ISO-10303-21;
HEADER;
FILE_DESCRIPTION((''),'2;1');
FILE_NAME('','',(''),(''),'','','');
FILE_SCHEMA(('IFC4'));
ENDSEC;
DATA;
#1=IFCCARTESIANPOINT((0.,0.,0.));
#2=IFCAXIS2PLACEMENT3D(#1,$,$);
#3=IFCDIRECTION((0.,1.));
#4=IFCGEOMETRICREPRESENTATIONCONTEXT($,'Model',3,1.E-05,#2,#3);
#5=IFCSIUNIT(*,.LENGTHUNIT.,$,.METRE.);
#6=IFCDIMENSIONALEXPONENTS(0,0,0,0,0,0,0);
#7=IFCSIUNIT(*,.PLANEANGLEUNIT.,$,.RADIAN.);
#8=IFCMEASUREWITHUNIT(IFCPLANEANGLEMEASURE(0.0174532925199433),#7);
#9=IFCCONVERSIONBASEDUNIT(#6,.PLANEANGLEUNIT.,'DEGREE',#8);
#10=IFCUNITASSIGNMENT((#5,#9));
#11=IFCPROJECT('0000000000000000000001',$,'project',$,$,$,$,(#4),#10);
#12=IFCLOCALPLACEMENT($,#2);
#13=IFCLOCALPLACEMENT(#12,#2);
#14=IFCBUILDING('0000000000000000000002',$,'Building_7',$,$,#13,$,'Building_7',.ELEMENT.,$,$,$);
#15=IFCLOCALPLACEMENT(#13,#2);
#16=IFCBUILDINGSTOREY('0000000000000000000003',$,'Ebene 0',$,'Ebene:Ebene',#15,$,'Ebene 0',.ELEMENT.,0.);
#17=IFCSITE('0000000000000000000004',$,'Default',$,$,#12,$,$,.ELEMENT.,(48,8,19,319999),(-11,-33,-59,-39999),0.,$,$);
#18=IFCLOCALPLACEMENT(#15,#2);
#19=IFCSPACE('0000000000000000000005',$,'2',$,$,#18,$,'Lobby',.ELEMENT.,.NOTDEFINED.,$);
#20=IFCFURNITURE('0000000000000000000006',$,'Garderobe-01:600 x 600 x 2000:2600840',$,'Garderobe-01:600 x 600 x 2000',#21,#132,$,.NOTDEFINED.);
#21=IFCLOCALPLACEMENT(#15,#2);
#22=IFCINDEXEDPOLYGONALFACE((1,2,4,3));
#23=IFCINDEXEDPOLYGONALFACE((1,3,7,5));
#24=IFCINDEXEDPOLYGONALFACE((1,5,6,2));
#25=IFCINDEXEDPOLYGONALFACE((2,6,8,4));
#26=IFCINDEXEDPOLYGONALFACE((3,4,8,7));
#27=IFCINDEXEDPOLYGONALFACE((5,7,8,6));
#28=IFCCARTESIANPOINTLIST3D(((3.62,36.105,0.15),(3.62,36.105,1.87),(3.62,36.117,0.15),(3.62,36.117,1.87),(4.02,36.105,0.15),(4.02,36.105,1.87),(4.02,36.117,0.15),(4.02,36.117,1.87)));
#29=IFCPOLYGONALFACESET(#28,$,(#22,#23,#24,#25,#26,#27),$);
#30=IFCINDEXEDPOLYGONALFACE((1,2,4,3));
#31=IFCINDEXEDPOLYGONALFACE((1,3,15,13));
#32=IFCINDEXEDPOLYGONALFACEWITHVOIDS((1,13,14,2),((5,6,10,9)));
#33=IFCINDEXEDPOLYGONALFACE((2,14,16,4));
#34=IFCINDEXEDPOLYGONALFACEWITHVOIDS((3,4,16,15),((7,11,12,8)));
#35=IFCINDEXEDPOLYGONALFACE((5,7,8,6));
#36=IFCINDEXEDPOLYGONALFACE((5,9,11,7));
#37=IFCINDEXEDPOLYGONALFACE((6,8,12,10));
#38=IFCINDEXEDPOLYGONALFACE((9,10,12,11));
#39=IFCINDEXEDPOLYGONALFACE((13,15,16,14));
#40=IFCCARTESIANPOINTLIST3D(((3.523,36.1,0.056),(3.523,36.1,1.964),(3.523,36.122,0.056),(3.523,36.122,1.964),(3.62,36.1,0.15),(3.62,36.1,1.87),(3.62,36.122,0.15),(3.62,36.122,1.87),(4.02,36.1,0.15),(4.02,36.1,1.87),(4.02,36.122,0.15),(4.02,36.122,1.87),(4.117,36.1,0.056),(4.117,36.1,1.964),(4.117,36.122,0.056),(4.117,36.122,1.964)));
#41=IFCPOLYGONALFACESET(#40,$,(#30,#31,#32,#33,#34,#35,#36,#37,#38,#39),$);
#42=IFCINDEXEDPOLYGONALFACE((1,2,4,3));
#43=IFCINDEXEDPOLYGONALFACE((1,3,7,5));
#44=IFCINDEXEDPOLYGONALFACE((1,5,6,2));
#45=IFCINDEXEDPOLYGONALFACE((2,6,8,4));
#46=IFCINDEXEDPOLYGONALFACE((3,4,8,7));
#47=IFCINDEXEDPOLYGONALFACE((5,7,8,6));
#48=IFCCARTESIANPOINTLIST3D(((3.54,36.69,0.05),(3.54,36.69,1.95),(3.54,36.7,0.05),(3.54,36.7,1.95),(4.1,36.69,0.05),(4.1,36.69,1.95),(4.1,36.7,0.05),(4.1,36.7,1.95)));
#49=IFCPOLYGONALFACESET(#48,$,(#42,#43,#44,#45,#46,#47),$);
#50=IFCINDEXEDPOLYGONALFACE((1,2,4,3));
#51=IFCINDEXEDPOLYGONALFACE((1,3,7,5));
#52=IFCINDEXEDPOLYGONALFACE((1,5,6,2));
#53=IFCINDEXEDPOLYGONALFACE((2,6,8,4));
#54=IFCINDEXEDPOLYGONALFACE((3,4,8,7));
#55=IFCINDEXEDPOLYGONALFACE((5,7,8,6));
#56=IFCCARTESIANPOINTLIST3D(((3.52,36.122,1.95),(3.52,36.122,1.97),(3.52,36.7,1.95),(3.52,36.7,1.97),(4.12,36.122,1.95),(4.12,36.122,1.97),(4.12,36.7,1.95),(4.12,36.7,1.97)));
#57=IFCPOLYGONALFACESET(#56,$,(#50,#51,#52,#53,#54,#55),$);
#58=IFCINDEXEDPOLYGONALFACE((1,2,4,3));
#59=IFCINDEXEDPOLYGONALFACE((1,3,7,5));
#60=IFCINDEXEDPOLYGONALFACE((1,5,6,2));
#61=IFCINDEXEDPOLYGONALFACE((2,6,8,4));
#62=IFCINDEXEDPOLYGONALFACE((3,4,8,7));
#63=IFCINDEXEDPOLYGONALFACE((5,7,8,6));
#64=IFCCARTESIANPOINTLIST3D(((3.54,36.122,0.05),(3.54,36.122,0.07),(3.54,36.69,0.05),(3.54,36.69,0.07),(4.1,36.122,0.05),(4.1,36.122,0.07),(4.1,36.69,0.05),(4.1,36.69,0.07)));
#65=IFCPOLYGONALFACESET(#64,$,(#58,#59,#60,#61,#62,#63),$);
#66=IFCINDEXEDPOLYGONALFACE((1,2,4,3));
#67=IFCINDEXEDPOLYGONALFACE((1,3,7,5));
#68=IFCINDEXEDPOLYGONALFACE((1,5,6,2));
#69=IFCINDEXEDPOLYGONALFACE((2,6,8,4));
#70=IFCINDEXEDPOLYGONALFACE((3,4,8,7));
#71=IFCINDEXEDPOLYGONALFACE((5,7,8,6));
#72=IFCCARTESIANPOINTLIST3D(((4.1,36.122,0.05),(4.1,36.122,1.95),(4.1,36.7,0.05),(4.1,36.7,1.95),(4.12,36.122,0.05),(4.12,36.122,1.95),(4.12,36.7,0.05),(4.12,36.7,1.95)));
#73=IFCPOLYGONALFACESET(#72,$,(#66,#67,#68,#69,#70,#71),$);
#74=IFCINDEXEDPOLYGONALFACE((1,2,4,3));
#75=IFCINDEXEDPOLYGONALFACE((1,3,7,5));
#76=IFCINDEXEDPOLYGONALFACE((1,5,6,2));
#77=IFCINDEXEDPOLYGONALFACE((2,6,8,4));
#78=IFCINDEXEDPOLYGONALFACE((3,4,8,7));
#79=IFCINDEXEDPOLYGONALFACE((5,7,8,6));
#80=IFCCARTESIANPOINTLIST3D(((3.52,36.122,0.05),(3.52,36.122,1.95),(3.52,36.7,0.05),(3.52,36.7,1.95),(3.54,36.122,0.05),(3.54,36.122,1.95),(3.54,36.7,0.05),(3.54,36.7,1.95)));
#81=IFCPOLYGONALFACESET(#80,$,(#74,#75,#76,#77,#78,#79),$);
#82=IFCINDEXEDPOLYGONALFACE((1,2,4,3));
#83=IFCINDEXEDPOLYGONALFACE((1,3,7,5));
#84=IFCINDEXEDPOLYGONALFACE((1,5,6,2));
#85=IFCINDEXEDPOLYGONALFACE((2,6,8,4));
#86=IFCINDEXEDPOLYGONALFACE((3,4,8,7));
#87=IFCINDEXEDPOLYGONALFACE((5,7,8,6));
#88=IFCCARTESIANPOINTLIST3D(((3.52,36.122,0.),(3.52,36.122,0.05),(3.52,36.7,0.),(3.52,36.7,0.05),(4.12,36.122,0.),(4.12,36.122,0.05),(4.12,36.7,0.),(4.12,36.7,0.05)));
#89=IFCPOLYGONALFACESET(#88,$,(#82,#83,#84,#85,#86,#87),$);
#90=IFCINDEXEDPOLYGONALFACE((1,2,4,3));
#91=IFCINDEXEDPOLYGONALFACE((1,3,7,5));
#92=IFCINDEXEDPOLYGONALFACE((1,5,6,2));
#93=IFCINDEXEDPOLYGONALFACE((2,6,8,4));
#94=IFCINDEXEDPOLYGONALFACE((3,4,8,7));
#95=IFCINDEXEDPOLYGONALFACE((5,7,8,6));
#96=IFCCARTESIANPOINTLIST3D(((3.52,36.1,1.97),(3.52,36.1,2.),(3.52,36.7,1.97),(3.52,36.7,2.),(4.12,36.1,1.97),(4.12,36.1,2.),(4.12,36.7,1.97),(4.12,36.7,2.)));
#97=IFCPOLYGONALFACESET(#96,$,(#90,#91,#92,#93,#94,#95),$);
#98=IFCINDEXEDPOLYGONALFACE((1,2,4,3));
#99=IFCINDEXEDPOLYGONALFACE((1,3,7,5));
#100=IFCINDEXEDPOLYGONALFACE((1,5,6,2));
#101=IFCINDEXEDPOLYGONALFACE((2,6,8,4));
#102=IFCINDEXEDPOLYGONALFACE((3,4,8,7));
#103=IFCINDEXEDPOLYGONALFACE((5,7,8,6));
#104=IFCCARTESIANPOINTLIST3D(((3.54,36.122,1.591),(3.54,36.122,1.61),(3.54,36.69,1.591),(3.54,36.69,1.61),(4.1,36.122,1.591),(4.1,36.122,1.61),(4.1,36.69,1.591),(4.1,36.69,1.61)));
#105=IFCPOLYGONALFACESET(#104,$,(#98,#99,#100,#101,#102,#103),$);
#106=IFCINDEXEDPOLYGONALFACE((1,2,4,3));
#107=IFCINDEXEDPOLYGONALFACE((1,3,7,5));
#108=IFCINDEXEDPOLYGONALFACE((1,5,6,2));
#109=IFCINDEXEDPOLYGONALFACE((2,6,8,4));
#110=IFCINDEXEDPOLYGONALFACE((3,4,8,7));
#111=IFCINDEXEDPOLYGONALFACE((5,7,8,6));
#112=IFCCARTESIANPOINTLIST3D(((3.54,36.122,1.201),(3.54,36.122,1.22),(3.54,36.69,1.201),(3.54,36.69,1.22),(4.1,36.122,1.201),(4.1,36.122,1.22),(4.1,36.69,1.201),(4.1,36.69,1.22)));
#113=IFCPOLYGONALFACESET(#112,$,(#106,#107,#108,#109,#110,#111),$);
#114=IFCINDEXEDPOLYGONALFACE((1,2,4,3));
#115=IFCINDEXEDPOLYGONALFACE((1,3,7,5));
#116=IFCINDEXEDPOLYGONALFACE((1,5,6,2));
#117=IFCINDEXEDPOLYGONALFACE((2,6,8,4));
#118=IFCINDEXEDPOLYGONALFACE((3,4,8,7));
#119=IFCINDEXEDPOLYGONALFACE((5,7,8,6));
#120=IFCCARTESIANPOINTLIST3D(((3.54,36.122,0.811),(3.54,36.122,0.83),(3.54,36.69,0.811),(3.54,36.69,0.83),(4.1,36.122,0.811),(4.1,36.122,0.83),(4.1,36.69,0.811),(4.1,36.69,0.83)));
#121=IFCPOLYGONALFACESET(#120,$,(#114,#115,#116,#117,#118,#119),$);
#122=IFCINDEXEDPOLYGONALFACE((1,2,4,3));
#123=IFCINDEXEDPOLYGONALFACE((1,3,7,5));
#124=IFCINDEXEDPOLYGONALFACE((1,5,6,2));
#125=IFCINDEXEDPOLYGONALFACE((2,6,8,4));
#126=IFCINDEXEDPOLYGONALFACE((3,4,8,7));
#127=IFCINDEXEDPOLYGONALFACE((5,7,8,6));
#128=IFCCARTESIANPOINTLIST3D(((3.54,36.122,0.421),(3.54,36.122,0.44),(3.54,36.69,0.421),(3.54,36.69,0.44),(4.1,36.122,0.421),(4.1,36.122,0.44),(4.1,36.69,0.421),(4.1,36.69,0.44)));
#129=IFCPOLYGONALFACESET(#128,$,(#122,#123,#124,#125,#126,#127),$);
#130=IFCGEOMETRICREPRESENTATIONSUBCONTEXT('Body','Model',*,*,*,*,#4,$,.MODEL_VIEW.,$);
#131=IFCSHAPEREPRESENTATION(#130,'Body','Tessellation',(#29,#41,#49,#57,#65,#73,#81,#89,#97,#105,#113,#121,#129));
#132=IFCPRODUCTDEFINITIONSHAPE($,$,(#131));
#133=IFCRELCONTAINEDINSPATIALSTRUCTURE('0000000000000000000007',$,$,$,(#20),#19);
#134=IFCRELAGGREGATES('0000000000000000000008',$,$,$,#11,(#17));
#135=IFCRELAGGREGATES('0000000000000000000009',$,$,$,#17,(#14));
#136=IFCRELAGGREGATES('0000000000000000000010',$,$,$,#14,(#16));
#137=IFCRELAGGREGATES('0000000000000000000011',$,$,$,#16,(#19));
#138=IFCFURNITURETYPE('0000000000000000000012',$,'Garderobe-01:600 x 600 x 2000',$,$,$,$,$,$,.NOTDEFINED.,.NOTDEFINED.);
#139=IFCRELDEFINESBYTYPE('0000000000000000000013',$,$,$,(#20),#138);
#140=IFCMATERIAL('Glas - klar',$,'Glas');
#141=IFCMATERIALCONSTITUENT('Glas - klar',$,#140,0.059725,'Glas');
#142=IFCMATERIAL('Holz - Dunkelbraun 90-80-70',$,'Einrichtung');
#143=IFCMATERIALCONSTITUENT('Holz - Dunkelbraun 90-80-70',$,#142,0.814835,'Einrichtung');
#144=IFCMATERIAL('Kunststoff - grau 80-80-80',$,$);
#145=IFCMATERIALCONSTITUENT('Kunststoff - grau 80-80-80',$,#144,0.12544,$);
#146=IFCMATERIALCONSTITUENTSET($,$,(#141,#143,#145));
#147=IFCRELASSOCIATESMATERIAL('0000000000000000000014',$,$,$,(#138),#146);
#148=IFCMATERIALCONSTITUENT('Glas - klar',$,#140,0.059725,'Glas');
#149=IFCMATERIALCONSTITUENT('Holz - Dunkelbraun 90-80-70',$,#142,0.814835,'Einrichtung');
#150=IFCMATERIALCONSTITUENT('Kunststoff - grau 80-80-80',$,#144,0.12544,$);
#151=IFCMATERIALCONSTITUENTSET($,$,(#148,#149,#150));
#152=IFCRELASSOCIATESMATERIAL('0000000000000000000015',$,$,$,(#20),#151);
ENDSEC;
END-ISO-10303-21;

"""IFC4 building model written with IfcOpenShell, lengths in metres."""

from ifc_helpers import new_model, entity, si_unit, converted_unit, direction, frame, origin, place, context, subcontext, project, spatial, indexed_curve, outline, extrude, source, transform, mapped, material, constituent, constituent_set, type_object, type_shapes, element, save


model = new_model("IFC4")

# Units and contexts
model_context = context("Model", 3, precision=1e-05, world=origin(), true_north=direction((0.0, 1.0)))
body_context = subcontext(model_context, "Body", "Model", "MODEL_VIEW")
ifc_project = project(units=[si_unit("LENGTHUNIT", "METRE"), converted_unit("PLANEANGLEUNIT", "DEGREE", entity("IfcPlaneAngleMeasure", 0.0174532925199433), si_unit("PLANEANGLEUNIT", "RADIAN"), dimensions=[0, 0, 0, 0, 0, 0, 0])], contexts=[model_context])

# Site, building, storey
site_placement = place(None, origin())
site = spatial("IfcSite", under=ifc_project, at=site_placement, Name="Default", CompositionType="ELEMENT", RefLatitude=(48, 8, 19, 319999), RefLongitude=(-11, -33, -59, -39999), RefElevation=0.0)
building_placement = place(site_placement, origin())
building = spatial("IfcBuilding", under=site, at=building_placement, Name="Building_7", LongName="Building_7", CompositionType="ELEMENT")
storey_placement = place(building_placement, origin())
storey = spatial("IfcBuildingStorey", under=building, at=storey_placement, Name="Ebene 0", ObjectType="Ebene:Ebene", LongName="Ebene 0", CompositionType="ELEMENT", Elevation=0.0)

# Shared definitions
space_1_placement = place(storey_placement, origin())
space_1 = spatial("IfcSpace", under=storey, at=space_1_placement, Name="2", LongName="Lobby", CompositionType="ELEMENT", PredefinedType="NOTDEFINED")

# Furniture
ifc_material_1 = material(Name="Glas - klar", Category="Glas")
ifc_material_2 = material(Name="Holz - Dunkelbraun 90-80-70", Category="Einrichtung")
ifc_material_3 = material(Name="Kunststoff - grau 80-80-80")
ifc_constituent_1 = constituent(ifc_material_1, Name="Glas - klar", Category="Glas", fraction=0.059725)
ifc_constituent_2 = constituent(ifc_material_2, Name="Holz - Dunkelbraun 90-80-70", Category="Einrichtung", fraction=0.814835)
ifc_constituent_3 = constituent(ifc_material_3, Name="Kunststoff - grau 80-80-80", fraction=0.12544)
ifc_constituent_set_1 = constituent_set(constituents=[ifc_constituent_1, ifc_constituent_2, ifc_constituent_3])
furniture_type_1 = type_object("IfcFurnitureType", Name="Garderobe-01:600 x 600 x 2000", AssemblyPlace="NOTDEFINED", PredefinedType="NOTDEFINED", material=ifc_constituent_set_1)
shared_shape_1 = source(origin(), body_context, "Body", "SweptSolid", [
    extrude(outline(indexed_curve([(-0.006, -0.2), (0.006, -0.2), (0.006, 0.2), (-0.006, 0.2), (-0.006, -0.2)], self_intersect=False)), frame((0.0, -0.289, 0.15), z_axis=(0.0, 0.0, 1.0), x_axis=(0.0, 1.0, 0.0)), (0.0, 0.0, 1.0), 1.72),
    extrude(outline(indexed_curve([(-0.954, -0.297), (0.954, -0.297), (0.954, 0.297), (-0.954, 0.297), (-0.954, -0.297)], self_intersect=False), holes=[indexed_curve([(-0.86, 0.2), (0.86, 0.2), (0.86, -0.2), (-0.86, -0.2), (-0.86, 0.2)], self_intersect=False)]), frame((0.0, -0.3, 1.01), z_axis=(0.0, 1.0, 0.0), x_axis=(0.0, 0.0, -1.0)), (0.0, 0.0, 1.0), 0.022),
    extrude(outline(indexed_curve([(-0.28, -0.005), (0.28, -0.005), (0.28, 0.005), (-0.28, 0.005), (-0.28, -0.005)], self_intersect=False)), frame((0.0, 0.295, 0.05), z_axis=(0.0, 0.0, 1.0), x_axis=(-1.0, 0.0, 0.0)), (0.0, 0.0, 1.0), 1.9),
    extrude(outline(indexed_curve([(-0.3, -0.289), (0.3, -0.289), (0.3, 0.289), (-0.3, 0.289), (-0.3, -0.289)], self_intersect=False)), frame((0.0, 0.011, 1.95), z_axis=(0.0, 0.0, 1.0), x_axis=(-1.0, 0.0, 0.0)), (0.0, 0.0, 1.0), 0.02),
    extrude(outline(indexed_curve([(-0.28, -0.284), (0.28, -0.284), (0.28, 0.284), (-0.28, 0.284), (-0.28, -0.284)], self_intersect=False)), frame((0.0, 0.006, 0.05), z_axis=(0.0, 0.0, 1.0), x_axis=(-1.0, 0.0, 0.0)), (0.0, 0.0, 1.0), 0.02),
    extrude(outline(indexed_curve([(-0.01, -0.289), (0.01, -0.289), (0.01, 0.289), (-0.01, 0.289), (-0.01, -0.289)], self_intersect=False)), frame((0.29, 0.011, 0.05), z_axis=(0.0, 0.0, 1.0), x_axis=(-1.0, 0.0, 0.0)), (0.0, 0.0, 1.0), 1.9),
    extrude(outline(indexed_curve([(-0.01, -0.289), (0.01, -0.289), (0.01, 0.289), (-0.01, 0.289), (-0.01, -0.289)], self_intersect=False)), frame((-0.29, 0.011, 0.05), z_axis=(0.0, 0.0, 1.0), x_axis=(-1.0, 0.0, 0.0)), (0.0, 0.0, 1.0), 1.9),
    extrude(outline(indexed_curve([(-0.3, -0.289), (0.3, -0.289), (0.3, 0.289), (-0.3, 0.289), (-0.3, -0.289)], self_intersect=False)), frame((0.0, 0.011, 0.0), z_axis=(0.0, 0.0, 1.0), x_axis=(-1.0, 0.0, 0.0)), (0.0, 0.0, 1.0), 0.05),
    extrude(outline(indexed_curve([(-0.3, -0.3), (0.3, -0.3), (0.3, 0.3), (-0.3, 0.3), (-0.3, -0.3)], self_intersect=False)), frame((0.0, 0.0, 1.97), z_axis=(0.0, 0.0, 1.0), x_axis=(-1.0, 0.0, 0.0)), (0.0, 0.0, 1.0), 0.03),
    extrude(outline(indexed_curve([(-0.28, -0.284), (0.28, -0.284), (0.28, 0.284), (-0.28, 0.284), (-0.28, -0.284)], self_intersect=False)), frame((0.0, 0.006, 1.591), z_axis=(0.0, 0.0, 1.0), x_axis=(-1.0, 0.0, 0.0)), (0.0, 0.0, 1.0), 0.019),
    extrude(outline(indexed_curve([(-0.28, -0.284), (0.28, -0.284), (0.28, 0.284), (-0.28, 0.284), (-0.28, -0.284)], self_intersect=False)), frame((0.0, 0.006, 1.201), z_axis=(0.0, 0.0, 1.0), x_axis=(-1.0, 0.0, 0.0)), (0.0, 0.0, 1.0), 0.019),
    extrude(outline(indexed_curve([(-0.28, -0.284), (0.28, -0.284), (0.28, 0.284), (-0.28, 0.284), (-0.28, -0.284)], self_intersect=False)), frame((0.0, 0.006, 0.811), z_axis=(0.0, 0.0, 1.0), x_axis=(-1.0, 0.0, 0.0)), (0.0, 0.0, 1.0), 0.019),
    extrude(outline(indexed_curve([(-0.28, -0.284), (0.28, -0.284), (0.28, 0.284), (-0.28, 0.284), (-0.28, -0.284)], self_intersect=False)), frame((0.0, 0.006, 0.421), z_axis=(0.0, 0.0, 1.0), x_axis=(-1.0, 0.0, 0.0)), (0.0, 0.0, 1.0), 0.019),
])
type_shapes(furniture_type_1, [shared_shape_1])
ifc_constituent_4 = constituent(ifc_material_1, Name="Glas - klar", Category="Glas", fraction=0.059725)
ifc_constituent_5 = constituent(ifc_material_2, Name="Holz - Dunkelbraun 90-80-70", Category="Einrichtung", fraction=0.814835)
ifc_constituent_6 = constituent(ifc_material_3, Name="Kunststoff - grau 80-80-80", fraction=0.12544)
ifc_constituent_set_2 = constituent_set(constituents=[ifc_constituent_4, ifc_constituent_5, ifc_constituent_6])
furniture_1_placement = place(space_1_placement, frame((3.82, 36.4, 0.0)))
element("IfcFurniture", 1, at=furniture_1_placement, inside=space_1, type_object=furniture_type_1, material=ifc_constituent_set_2, Name="Garderobe-01:600 x 600 x 2000:2600840", ObjectType="Garderobe-01:600 x 600 x 2000", PredefinedType="NOTDEFINED", context=body_context, shape_type="MappedRepresentation", body=[
    mapped(shared_shape_1, transform((0.0, 0.0, 0.0), scale=1.0)),
])

save(model, "model.ifc")
